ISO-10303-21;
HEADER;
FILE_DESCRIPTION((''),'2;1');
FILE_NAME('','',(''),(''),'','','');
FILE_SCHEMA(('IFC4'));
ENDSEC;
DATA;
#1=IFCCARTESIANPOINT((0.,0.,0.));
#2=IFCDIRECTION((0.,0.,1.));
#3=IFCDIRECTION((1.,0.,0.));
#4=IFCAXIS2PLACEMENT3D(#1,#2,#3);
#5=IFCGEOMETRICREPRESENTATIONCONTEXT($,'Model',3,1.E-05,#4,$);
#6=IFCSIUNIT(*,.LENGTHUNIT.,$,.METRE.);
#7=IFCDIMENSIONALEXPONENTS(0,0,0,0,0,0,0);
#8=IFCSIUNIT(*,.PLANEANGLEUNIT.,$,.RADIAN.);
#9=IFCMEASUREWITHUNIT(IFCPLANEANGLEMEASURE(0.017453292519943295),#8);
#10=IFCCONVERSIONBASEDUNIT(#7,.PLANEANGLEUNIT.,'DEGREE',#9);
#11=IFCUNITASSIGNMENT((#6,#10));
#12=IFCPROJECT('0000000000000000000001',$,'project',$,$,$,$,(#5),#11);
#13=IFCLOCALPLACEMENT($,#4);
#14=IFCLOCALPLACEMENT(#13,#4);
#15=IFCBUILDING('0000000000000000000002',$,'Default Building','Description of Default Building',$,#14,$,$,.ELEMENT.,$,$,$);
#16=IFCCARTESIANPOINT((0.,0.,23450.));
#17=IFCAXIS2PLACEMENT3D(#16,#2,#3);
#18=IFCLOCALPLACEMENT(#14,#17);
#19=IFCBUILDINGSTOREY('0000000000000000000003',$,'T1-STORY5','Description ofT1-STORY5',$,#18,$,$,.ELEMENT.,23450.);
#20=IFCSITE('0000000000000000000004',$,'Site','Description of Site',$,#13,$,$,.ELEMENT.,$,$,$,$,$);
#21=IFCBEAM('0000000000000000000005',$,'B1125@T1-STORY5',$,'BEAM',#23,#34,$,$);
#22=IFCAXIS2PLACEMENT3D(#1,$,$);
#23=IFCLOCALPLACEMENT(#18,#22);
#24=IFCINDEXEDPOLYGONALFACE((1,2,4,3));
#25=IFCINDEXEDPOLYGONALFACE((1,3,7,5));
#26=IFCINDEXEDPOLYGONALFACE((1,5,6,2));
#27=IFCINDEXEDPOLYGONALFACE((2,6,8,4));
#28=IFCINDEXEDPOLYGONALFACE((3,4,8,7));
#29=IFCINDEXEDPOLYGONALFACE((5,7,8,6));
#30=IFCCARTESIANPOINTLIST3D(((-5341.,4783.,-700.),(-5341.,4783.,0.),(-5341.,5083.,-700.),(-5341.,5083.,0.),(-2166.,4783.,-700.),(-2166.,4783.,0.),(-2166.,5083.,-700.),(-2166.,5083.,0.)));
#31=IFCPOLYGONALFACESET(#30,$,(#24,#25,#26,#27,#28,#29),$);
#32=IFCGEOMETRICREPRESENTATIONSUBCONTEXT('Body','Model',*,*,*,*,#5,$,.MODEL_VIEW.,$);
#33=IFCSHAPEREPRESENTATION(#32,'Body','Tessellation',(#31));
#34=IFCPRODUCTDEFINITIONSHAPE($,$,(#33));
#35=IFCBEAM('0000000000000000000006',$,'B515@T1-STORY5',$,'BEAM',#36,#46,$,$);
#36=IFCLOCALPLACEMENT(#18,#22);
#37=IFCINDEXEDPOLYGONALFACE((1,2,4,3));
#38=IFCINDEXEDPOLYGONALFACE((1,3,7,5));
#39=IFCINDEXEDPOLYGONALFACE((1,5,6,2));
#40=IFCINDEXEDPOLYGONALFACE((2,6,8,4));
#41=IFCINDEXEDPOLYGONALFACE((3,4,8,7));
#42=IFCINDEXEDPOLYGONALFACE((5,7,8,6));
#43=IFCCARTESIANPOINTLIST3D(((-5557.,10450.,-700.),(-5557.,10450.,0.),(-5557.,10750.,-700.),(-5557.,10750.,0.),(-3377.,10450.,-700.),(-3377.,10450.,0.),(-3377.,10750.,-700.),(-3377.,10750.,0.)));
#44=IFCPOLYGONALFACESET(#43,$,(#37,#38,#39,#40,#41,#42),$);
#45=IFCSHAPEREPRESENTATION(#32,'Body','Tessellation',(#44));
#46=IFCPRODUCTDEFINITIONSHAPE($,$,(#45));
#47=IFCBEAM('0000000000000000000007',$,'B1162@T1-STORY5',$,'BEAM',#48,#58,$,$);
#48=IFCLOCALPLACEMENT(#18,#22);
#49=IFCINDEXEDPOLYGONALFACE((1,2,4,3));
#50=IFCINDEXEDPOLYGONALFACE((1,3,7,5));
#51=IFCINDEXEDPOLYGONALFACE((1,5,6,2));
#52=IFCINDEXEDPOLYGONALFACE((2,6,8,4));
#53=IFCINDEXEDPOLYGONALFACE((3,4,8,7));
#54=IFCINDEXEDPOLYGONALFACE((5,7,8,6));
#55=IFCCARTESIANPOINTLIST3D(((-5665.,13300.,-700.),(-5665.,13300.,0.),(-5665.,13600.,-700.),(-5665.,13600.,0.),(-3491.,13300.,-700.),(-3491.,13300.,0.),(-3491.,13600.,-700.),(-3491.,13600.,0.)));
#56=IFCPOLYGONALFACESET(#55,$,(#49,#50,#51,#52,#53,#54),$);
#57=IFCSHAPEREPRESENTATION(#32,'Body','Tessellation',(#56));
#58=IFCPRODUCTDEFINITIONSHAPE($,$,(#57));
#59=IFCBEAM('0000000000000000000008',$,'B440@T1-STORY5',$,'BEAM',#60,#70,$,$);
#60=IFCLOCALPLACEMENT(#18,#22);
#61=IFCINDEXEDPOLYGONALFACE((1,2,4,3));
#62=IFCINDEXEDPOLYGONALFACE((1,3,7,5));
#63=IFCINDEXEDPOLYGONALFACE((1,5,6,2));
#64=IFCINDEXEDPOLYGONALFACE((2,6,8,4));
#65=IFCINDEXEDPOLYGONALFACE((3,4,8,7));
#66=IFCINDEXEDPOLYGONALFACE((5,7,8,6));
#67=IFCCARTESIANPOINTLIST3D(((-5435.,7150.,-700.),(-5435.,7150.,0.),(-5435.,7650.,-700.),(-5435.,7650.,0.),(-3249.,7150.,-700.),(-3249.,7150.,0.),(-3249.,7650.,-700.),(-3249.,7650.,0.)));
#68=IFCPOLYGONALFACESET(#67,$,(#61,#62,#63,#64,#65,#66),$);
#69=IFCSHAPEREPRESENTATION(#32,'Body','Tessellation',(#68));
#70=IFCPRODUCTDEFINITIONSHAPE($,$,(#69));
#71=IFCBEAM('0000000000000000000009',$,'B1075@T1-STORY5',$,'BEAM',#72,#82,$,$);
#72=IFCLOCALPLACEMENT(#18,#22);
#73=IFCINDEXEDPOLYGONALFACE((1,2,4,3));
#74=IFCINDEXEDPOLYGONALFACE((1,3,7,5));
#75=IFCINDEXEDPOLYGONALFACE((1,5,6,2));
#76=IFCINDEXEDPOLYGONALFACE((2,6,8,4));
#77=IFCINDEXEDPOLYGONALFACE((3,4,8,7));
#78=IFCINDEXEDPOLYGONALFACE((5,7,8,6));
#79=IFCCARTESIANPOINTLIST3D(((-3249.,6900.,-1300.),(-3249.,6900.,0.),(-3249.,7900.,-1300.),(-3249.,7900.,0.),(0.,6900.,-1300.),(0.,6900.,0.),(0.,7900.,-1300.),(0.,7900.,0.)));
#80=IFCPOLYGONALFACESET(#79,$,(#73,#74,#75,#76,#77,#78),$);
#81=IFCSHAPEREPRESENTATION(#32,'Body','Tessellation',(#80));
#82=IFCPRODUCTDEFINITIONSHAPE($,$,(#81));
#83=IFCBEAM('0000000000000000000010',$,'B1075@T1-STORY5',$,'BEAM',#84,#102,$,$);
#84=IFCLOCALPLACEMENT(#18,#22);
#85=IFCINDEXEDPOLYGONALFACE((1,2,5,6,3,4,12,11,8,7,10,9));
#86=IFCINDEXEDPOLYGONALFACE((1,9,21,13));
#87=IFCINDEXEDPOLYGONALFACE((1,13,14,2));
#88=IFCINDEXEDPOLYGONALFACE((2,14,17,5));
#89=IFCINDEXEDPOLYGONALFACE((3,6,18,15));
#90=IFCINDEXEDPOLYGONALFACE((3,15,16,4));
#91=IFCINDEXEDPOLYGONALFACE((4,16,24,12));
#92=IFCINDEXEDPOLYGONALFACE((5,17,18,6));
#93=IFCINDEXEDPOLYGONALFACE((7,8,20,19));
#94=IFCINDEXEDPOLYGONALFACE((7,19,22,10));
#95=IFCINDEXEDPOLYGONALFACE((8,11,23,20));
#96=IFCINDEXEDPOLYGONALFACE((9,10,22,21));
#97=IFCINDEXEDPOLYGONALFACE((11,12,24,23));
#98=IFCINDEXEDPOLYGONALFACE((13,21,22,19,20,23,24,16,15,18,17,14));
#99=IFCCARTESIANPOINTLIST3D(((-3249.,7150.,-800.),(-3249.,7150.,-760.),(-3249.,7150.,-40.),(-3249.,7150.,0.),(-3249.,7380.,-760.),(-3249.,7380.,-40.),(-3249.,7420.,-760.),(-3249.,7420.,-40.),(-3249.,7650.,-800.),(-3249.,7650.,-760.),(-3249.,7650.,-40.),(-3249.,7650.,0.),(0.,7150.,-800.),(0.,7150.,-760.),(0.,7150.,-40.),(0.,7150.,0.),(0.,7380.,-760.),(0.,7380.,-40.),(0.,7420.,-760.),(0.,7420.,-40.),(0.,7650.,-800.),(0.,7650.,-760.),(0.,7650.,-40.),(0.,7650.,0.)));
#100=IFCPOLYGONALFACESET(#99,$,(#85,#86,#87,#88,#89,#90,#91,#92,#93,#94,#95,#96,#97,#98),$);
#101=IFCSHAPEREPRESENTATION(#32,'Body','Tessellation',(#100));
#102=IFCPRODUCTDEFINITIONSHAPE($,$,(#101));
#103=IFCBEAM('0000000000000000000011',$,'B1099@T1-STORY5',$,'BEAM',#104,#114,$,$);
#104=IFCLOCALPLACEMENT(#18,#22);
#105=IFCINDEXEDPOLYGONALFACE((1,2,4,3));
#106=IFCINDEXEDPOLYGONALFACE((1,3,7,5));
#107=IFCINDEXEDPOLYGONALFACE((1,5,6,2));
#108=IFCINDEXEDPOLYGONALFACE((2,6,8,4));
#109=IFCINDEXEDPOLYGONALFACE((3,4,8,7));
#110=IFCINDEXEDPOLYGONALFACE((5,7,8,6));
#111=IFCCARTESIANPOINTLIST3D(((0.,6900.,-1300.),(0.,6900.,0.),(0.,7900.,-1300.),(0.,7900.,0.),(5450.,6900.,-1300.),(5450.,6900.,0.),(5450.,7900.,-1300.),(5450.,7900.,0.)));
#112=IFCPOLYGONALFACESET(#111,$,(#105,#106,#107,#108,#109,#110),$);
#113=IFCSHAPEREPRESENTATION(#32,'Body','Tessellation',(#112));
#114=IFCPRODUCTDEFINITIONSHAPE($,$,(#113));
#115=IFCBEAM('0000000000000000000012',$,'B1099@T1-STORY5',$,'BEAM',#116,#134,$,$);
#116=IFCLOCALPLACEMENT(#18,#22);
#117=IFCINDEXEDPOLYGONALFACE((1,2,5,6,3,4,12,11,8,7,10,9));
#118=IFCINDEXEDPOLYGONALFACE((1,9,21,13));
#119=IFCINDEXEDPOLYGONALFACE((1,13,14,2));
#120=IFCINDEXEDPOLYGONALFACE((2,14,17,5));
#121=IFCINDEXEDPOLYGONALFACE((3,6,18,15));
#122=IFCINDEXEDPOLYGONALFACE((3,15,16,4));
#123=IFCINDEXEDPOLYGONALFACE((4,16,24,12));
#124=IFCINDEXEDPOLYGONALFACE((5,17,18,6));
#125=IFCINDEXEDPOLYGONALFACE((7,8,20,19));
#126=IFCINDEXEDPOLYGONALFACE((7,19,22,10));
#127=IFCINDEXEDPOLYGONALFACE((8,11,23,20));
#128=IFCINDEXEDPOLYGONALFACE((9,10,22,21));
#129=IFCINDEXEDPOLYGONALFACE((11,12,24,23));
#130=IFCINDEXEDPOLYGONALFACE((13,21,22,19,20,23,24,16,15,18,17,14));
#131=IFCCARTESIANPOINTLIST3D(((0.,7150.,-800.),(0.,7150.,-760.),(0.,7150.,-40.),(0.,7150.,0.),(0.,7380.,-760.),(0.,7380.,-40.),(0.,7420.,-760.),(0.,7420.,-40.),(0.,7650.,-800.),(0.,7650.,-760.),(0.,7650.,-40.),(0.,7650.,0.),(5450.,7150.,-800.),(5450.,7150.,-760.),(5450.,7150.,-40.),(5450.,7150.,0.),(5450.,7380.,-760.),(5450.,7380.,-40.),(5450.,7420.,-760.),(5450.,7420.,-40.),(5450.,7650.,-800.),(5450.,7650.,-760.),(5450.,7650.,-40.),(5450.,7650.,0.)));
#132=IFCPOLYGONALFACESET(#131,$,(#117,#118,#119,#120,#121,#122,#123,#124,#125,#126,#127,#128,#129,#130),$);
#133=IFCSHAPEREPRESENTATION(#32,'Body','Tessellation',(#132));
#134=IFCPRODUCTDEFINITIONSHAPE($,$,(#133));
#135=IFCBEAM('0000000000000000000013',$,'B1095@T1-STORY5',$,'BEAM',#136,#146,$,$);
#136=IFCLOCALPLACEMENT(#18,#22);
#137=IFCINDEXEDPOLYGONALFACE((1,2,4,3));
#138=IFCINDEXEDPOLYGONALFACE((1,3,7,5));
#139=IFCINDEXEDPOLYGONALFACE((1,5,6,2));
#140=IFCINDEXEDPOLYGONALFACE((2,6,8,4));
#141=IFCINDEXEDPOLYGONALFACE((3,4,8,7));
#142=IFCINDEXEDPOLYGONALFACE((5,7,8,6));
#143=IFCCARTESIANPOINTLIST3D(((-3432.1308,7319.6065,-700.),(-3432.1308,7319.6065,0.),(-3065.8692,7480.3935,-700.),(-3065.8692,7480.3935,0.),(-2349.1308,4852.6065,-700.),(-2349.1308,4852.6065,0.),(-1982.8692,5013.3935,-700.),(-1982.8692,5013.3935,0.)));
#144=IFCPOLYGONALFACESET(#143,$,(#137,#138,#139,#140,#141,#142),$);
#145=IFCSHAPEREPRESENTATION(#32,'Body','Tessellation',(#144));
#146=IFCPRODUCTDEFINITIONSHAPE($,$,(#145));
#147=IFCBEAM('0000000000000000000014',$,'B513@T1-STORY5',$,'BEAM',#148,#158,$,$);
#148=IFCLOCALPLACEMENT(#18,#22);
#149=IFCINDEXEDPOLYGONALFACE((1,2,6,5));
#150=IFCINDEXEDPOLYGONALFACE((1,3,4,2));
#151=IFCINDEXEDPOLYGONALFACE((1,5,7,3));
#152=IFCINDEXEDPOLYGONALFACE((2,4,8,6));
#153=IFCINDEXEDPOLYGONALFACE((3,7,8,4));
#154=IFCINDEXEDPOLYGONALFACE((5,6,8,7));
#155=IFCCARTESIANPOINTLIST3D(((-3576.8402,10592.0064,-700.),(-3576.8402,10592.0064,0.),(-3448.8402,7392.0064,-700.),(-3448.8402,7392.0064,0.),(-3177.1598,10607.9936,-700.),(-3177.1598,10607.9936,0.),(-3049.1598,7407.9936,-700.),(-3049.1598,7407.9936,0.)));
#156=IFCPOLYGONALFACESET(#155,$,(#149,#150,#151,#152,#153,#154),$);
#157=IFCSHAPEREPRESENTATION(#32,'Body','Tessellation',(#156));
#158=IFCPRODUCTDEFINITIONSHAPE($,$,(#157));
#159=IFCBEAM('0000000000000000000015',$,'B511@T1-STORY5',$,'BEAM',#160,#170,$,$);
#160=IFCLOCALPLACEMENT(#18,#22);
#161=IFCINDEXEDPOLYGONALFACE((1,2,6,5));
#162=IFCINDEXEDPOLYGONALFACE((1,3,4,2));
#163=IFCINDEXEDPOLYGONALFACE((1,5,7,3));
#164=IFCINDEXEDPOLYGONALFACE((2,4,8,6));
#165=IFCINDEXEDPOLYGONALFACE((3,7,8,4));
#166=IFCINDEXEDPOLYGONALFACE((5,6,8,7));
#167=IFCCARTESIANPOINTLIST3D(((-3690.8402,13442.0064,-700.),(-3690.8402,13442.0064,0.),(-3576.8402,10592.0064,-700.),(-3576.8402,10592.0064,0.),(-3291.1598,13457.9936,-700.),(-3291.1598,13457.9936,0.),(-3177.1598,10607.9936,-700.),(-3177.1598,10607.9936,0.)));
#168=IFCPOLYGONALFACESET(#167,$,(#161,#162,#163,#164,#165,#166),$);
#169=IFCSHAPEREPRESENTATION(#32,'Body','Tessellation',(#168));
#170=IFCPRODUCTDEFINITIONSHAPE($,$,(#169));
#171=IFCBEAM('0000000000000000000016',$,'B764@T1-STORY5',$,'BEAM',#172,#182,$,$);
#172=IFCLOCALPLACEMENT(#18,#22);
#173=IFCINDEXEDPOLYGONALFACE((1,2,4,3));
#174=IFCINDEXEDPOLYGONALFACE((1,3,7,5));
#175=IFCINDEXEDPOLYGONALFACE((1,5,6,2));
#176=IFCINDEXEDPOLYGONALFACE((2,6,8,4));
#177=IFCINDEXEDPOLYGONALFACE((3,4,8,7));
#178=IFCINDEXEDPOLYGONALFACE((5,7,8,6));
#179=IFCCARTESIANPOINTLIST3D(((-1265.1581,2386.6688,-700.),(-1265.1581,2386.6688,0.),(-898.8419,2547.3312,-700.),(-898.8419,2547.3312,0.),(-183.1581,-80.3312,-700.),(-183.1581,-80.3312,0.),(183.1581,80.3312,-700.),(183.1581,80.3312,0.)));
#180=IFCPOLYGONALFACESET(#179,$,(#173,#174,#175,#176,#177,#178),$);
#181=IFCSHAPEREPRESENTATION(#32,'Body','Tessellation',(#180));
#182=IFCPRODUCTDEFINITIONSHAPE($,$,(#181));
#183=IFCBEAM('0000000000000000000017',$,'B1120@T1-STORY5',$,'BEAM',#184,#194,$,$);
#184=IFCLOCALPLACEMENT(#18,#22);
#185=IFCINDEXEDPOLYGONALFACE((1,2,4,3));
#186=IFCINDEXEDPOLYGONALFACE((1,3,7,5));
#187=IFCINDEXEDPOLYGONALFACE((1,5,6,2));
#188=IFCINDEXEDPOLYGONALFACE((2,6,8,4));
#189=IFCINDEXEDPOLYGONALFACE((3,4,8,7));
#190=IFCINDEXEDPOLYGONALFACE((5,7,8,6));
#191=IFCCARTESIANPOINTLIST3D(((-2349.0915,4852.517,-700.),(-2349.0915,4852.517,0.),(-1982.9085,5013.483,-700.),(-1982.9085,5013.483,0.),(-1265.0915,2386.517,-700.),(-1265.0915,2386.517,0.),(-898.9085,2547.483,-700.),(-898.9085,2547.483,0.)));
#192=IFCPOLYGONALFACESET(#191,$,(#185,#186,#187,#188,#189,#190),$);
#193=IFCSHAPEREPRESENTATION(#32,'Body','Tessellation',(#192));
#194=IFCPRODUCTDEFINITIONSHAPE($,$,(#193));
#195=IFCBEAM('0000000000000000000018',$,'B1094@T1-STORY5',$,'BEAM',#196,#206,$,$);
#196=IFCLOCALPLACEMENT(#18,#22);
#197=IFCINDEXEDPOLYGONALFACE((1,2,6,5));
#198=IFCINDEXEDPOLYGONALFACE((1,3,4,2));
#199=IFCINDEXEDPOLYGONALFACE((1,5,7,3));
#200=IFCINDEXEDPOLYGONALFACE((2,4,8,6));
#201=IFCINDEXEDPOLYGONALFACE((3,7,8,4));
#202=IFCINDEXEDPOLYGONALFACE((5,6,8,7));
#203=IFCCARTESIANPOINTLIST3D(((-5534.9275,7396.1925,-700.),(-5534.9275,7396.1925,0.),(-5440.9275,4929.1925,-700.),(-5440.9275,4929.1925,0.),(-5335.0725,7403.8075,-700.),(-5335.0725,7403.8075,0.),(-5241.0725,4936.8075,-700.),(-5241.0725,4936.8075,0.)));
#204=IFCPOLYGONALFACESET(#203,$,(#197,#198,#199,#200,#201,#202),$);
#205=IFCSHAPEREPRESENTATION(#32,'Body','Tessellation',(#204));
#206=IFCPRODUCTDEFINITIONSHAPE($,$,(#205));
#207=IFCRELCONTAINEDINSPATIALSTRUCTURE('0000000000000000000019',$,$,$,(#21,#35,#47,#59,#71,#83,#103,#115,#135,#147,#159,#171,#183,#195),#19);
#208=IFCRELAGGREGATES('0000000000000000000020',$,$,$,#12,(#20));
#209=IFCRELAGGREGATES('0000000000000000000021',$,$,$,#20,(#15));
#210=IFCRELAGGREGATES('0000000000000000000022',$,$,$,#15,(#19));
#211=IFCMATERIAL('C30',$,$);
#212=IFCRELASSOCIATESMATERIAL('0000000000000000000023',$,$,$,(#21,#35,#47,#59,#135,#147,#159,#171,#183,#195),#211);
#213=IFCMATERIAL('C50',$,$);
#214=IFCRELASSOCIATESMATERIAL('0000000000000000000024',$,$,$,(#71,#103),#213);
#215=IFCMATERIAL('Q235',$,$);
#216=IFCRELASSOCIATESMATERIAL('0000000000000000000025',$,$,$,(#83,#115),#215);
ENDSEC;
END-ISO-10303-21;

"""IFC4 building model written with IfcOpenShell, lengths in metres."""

from ifc_helpers import new_model, entity, si_unit, converted_unit, frame, origin_with_axes, place, context, subcontext, project, spatial, rectangle, i_section, extrude, material, element, save


model = new_model("IFC4")

# Units and contexts
model_context = context("Model", 3, precision=1e-05, world=origin_with_axes())
body_context = subcontext(model_context, "Body", "Model", "MODEL_VIEW")
ifc_project = project(units=[si_unit("LENGTHUNIT", "METRE"), converted_unit("PLANEANGLEUNIT", "DEGREE", entity("IfcPlaneAngleMeasure", 0.017453292519943295), si_unit("PLANEANGLEUNIT", "RADIAN"), dimensions=[0, 0, 0, 0, 0, 0, 0])], contexts=[model_context])

# Site, building, storey
site_placement = place(None, origin_with_axes())
site = spatial("IfcSite", under=ifc_project, at=site_placement, Name="Site", Description="Description of Site", CompositionType="ELEMENT")
building_placement = place(site_placement, origin_with_axes())
building = spatial("IfcBuilding", under=site, at=building_placement, Name="Default Building", Description="Description of Default Building", CompositionType="ELEMENT")
storey_placement = place(building_placement, frame((0.0, 0.0, 23450.0), z_axis=(0.0, 0.0, 1.0), x_axis=(1.0, 0.0, 0.0)))
storey = spatial("IfcBuildingStorey", under=building, at=storey_placement, Name="T1-STORY5", Description="Description ofT1-STORY5", CompositionType="ELEMENT", Elevation=23450.0)

# Beams
ifc_material_1 = material(Name="C30")
beam_1_placement = place(storey_placement, frame((-5341.0, 4933.0, -350.0), z_axis=(1.0, 0.0, 0.0), x_axis=(0.0, 1.0, 0.0)))
element("IfcBeam", 1, at=beam_1_placement, inside=storey, material=ifc_material_1, Name="B1125@T1-STORY5", ObjectType="BEAM", context=body_context, shape_type="SweptSolid", body=[
    extrude(rectangle(XDim=300.0, YDim=700.0), origin_with_axes(), (0.0, 0.0, 1.0), 3175.0),
])
beam_2_placement = place(storey_placement, frame((-5557.0, 10600.0, -350.0), z_axis=(1.0, 0.0, 0.0), x_axis=(0.0, 1.0, 0.0)))
element("IfcBeam", 2, at=beam_2_placement, inside=storey, material=ifc_material_1, Name="B515@T1-STORY5", ObjectType="BEAM", context=body_context, shape_type="SweptSolid", body=[
    extrude(rectangle(XDim=300.0, YDim=700.0), origin_with_axes(), (0.0, 0.0, 1.0), 2180.0),
])
beam_3_placement = place(storey_placement, frame((-5665.0, 13450.0, -350.0), z_axis=(1.0, 0.0, 0.0), x_axis=(0.0, 1.0, 0.0)))
element("IfcBeam", 3, at=beam_3_placement, inside=storey, material=ifc_material_1, Name="B1162@T1-STORY5", ObjectType="BEAM", context=body_context, shape_type="SweptSolid", body=[
    extrude(rectangle(XDim=300.0, YDim=700.0), origin_with_axes(), (0.0, 0.0, 1.0), 2174.0),
])
beam_4_placement = place(storey_placement, frame((-5435.0, 7400.0, -350.0), z_axis=(1.0, 0.0, 0.0), x_axis=(0.0, 1.0, 0.0)))
element("IfcBeam", 4, at=beam_4_placement, inside=storey, material=ifc_material_1, Name="B440@T1-STORY5", ObjectType="BEAM", context=body_context, shape_type="SweptSolid", body=[
    extrude(rectangle(XDim=500.0, YDim=700.0), origin_with_axes(), (0.0, 0.0, 1.0), 2186.0),
])
ifc_material_2 = material(Name="C50")
beam_5_placement = place(storey_placement, frame((-3249.0, 7400.0, -650.0), z_axis=(1.0, 0.0, 0.0), x_axis=(0.0, 1.0, 0.0)))
element("IfcBeam", 5, at=beam_5_placement, inside=storey, material=ifc_material_2, Name="B1075@T1-STORY5", ObjectType="BEAM", context=body_context, shape_type="SweptSolid", body=[
    extrude(rectangle(XDim=1000.0, YDim=1300.0), origin_with_axes(), (0.0, 0.0, 1.0), 3249.0),
])
ifc_material_3 = material(Name="Q235")
beam_6_placement = place(storey_placement, frame((-3249.0, 7400.0, -400.0), z_axis=(1.0, 0.0, 0.0), x_axis=(0.0, 1.0, 0.0)))
element("IfcBeam", 6, at=beam_6_placement, inside=storey, material=ifc_material_3, Name="B1075@T1-STORY5", ObjectType="BEAM", context=body_context, shape_type="SweptSolid", body=[
    extrude(i_section(OverallWidth=500.0, OverallDepth=800.0, WebThickness=40.0, FlangeThickness=40.0, FilletRadius=0.0), origin_with_axes(), (0.0, 0.0, 1.0), 3249.0),
])
beam_7_placement = place(storey_placement, frame((0.0, 7400.0, -650.0), z_axis=(1.0, 0.0, 0.0), x_axis=(0.0, 1.0, 0.0)))
element("IfcBeam", 7, at=beam_7_placement, inside=storey, material=ifc_material_2, Name="B1099@T1-STORY5", ObjectType="BEAM", context=body_context, shape_type="SweptSolid", body=[
    extrude(rectangle(XDim=1000.0, YDim=1300.0), origin_with_axes(), (0.0, 0.0, 1.0), 5450.0),
])
beam_8_placement = place(storey_placement, frame((0.0, 7400.0, -400.0), z_axis=(1.0, 0.0, 0.0), x_axis=(0.0, 1.0, 0.0)))
element("IfcBeam", 8, at=beam_8_placement, inside=storey, material=ifc_material_3, Name="B1099@T1-STORY5", ObjectType="BEAM", context=body_context, shape_type="SweptSolid", body=[
    extrude(i_section(OverallWidth=500.0, OverallDepth=800.0, WebThickness=40.0, FlangeThickness=40.0, FilletRadius=0.0), origin_with_axes(), (0.0, 0.0, 1.0), 5450.0),
])
beam_9_placement = place(storey_placement, frame((-3249.0, 7400.0, -350.0), z_axis=(0.401967, -0.915654, 0.0), x_axis=(0.915654, 0.401967, 0.0)))
element("IfcBeam", 9, at=beam_9_placement, inside=storey, material=ifc_material_1, Name="B1095@T1-STORY5", ObjectType="BEAM", context=body_context, shape_type="SweptSolid", body=[
    extrude(rectangle(XDim=400.0, YDim=700.0), origin_with_axes(), (0.0, 0.0, 1.0), 2694.2491),
])
beam_10_placement = place(storey_placement, frame((-3377.0, 10600.0, -350.0), z_axis=(0.039968, -0.999201, 0.0), x_axis=(0.999201, 0.039968, 0.0)))
element("IfcBeam", 10, at=beam_10_placement, inside=storey, material=ifc_material_1, Name="B513@T1-STORY5", ObjectType="BEAM", context=body_context, shape_type="SweptSolid", body=[
    extrude(rectangle(XDim=400.0, YDim=700.0), origin_with_axes(), (0.0, 0.0, 1.0), 3202.559),
])
beam_11_placement = place(storey_placement, frame((-3491.0, 13450.0, -350.0), z_axis=(0.039968, -0.999201, 0.0), x_axis=(0.999201, 0.039968, 0.0)))
element("IfcBeam", 11, at=beam_11_placement, inside=storey, material=ifc_material_1, Name="B511@T1-STORY5", ObjectType="BEAM", context=body_context, shape_type="SweptSolid", body=[
    extrude(rectangle(XDim=400.0, YDim=700.0), origin_with_axes(), (0.0, 0.0, 1.0), 2852.2791),
])
beam_12_placement = place(storey_placement, frame((-1082.0, 2467.0, -350.0), z_axis=(0.401656, -0.915791, 0.0), x_axis=(0.915791, 0.401656, 0.0)))
element("IfcBeam", 12, at=beam_12_placement, inside=storey, material=ifc_material_1, Name="B764@T1-STORY5", ObjectType="BEAM", context=body_context, shape_type="SweptSolid", body=[
    extrude(rectangle(XDim=400.0, YDim=700.0), origin_with_axes(), (0.0, 0.0, 1.0), 2693.8472),
])
beam_13_placement = place(storey_placement, frame((-2166.0, 4933.0, -350.0), z_axis=(0.402415, -0.915457, 0.0), x_axis=(0.915457, 0.402415, 0.0)))
element("IfcBeam", 13, at=beam_13_placement, inside=storey, material=ifc_material_1, Name="B1120@T1-STORY5", ObjectType="BEAM", context=body_context, shape_type="SweptSolid", body=[
    extrude(rectangle(XDim=400.0, YDim=700.0), origin_with_axes(), (0.0, 0.0, 1.0), 2693.7357),
])
for number, where, z_axis, x_axis, name in (
    (14, (-5435.0, 7400.0, -350.0), (0.038075, -0.999275, 0.0), (0.999275, 0.038075, 0.0), "B1094@T1-STORY5"),
):
    element("IfcBeam", number, at=place(storey_placement, frame(where, z_axis=z_axis, x_axis=x_axis)), inside=storey, material=ifc_material_1, Name=name, ObjectType="BEAM", context=body_context, shape_type="SweptSolid", body=[
        extrude(rectangle(XDim=200.0, YDim=700.0), origin_with_axes(), (0.0, 0.0, 1.0), 2468.7902),
    ])

save(model, "model.ifc")
